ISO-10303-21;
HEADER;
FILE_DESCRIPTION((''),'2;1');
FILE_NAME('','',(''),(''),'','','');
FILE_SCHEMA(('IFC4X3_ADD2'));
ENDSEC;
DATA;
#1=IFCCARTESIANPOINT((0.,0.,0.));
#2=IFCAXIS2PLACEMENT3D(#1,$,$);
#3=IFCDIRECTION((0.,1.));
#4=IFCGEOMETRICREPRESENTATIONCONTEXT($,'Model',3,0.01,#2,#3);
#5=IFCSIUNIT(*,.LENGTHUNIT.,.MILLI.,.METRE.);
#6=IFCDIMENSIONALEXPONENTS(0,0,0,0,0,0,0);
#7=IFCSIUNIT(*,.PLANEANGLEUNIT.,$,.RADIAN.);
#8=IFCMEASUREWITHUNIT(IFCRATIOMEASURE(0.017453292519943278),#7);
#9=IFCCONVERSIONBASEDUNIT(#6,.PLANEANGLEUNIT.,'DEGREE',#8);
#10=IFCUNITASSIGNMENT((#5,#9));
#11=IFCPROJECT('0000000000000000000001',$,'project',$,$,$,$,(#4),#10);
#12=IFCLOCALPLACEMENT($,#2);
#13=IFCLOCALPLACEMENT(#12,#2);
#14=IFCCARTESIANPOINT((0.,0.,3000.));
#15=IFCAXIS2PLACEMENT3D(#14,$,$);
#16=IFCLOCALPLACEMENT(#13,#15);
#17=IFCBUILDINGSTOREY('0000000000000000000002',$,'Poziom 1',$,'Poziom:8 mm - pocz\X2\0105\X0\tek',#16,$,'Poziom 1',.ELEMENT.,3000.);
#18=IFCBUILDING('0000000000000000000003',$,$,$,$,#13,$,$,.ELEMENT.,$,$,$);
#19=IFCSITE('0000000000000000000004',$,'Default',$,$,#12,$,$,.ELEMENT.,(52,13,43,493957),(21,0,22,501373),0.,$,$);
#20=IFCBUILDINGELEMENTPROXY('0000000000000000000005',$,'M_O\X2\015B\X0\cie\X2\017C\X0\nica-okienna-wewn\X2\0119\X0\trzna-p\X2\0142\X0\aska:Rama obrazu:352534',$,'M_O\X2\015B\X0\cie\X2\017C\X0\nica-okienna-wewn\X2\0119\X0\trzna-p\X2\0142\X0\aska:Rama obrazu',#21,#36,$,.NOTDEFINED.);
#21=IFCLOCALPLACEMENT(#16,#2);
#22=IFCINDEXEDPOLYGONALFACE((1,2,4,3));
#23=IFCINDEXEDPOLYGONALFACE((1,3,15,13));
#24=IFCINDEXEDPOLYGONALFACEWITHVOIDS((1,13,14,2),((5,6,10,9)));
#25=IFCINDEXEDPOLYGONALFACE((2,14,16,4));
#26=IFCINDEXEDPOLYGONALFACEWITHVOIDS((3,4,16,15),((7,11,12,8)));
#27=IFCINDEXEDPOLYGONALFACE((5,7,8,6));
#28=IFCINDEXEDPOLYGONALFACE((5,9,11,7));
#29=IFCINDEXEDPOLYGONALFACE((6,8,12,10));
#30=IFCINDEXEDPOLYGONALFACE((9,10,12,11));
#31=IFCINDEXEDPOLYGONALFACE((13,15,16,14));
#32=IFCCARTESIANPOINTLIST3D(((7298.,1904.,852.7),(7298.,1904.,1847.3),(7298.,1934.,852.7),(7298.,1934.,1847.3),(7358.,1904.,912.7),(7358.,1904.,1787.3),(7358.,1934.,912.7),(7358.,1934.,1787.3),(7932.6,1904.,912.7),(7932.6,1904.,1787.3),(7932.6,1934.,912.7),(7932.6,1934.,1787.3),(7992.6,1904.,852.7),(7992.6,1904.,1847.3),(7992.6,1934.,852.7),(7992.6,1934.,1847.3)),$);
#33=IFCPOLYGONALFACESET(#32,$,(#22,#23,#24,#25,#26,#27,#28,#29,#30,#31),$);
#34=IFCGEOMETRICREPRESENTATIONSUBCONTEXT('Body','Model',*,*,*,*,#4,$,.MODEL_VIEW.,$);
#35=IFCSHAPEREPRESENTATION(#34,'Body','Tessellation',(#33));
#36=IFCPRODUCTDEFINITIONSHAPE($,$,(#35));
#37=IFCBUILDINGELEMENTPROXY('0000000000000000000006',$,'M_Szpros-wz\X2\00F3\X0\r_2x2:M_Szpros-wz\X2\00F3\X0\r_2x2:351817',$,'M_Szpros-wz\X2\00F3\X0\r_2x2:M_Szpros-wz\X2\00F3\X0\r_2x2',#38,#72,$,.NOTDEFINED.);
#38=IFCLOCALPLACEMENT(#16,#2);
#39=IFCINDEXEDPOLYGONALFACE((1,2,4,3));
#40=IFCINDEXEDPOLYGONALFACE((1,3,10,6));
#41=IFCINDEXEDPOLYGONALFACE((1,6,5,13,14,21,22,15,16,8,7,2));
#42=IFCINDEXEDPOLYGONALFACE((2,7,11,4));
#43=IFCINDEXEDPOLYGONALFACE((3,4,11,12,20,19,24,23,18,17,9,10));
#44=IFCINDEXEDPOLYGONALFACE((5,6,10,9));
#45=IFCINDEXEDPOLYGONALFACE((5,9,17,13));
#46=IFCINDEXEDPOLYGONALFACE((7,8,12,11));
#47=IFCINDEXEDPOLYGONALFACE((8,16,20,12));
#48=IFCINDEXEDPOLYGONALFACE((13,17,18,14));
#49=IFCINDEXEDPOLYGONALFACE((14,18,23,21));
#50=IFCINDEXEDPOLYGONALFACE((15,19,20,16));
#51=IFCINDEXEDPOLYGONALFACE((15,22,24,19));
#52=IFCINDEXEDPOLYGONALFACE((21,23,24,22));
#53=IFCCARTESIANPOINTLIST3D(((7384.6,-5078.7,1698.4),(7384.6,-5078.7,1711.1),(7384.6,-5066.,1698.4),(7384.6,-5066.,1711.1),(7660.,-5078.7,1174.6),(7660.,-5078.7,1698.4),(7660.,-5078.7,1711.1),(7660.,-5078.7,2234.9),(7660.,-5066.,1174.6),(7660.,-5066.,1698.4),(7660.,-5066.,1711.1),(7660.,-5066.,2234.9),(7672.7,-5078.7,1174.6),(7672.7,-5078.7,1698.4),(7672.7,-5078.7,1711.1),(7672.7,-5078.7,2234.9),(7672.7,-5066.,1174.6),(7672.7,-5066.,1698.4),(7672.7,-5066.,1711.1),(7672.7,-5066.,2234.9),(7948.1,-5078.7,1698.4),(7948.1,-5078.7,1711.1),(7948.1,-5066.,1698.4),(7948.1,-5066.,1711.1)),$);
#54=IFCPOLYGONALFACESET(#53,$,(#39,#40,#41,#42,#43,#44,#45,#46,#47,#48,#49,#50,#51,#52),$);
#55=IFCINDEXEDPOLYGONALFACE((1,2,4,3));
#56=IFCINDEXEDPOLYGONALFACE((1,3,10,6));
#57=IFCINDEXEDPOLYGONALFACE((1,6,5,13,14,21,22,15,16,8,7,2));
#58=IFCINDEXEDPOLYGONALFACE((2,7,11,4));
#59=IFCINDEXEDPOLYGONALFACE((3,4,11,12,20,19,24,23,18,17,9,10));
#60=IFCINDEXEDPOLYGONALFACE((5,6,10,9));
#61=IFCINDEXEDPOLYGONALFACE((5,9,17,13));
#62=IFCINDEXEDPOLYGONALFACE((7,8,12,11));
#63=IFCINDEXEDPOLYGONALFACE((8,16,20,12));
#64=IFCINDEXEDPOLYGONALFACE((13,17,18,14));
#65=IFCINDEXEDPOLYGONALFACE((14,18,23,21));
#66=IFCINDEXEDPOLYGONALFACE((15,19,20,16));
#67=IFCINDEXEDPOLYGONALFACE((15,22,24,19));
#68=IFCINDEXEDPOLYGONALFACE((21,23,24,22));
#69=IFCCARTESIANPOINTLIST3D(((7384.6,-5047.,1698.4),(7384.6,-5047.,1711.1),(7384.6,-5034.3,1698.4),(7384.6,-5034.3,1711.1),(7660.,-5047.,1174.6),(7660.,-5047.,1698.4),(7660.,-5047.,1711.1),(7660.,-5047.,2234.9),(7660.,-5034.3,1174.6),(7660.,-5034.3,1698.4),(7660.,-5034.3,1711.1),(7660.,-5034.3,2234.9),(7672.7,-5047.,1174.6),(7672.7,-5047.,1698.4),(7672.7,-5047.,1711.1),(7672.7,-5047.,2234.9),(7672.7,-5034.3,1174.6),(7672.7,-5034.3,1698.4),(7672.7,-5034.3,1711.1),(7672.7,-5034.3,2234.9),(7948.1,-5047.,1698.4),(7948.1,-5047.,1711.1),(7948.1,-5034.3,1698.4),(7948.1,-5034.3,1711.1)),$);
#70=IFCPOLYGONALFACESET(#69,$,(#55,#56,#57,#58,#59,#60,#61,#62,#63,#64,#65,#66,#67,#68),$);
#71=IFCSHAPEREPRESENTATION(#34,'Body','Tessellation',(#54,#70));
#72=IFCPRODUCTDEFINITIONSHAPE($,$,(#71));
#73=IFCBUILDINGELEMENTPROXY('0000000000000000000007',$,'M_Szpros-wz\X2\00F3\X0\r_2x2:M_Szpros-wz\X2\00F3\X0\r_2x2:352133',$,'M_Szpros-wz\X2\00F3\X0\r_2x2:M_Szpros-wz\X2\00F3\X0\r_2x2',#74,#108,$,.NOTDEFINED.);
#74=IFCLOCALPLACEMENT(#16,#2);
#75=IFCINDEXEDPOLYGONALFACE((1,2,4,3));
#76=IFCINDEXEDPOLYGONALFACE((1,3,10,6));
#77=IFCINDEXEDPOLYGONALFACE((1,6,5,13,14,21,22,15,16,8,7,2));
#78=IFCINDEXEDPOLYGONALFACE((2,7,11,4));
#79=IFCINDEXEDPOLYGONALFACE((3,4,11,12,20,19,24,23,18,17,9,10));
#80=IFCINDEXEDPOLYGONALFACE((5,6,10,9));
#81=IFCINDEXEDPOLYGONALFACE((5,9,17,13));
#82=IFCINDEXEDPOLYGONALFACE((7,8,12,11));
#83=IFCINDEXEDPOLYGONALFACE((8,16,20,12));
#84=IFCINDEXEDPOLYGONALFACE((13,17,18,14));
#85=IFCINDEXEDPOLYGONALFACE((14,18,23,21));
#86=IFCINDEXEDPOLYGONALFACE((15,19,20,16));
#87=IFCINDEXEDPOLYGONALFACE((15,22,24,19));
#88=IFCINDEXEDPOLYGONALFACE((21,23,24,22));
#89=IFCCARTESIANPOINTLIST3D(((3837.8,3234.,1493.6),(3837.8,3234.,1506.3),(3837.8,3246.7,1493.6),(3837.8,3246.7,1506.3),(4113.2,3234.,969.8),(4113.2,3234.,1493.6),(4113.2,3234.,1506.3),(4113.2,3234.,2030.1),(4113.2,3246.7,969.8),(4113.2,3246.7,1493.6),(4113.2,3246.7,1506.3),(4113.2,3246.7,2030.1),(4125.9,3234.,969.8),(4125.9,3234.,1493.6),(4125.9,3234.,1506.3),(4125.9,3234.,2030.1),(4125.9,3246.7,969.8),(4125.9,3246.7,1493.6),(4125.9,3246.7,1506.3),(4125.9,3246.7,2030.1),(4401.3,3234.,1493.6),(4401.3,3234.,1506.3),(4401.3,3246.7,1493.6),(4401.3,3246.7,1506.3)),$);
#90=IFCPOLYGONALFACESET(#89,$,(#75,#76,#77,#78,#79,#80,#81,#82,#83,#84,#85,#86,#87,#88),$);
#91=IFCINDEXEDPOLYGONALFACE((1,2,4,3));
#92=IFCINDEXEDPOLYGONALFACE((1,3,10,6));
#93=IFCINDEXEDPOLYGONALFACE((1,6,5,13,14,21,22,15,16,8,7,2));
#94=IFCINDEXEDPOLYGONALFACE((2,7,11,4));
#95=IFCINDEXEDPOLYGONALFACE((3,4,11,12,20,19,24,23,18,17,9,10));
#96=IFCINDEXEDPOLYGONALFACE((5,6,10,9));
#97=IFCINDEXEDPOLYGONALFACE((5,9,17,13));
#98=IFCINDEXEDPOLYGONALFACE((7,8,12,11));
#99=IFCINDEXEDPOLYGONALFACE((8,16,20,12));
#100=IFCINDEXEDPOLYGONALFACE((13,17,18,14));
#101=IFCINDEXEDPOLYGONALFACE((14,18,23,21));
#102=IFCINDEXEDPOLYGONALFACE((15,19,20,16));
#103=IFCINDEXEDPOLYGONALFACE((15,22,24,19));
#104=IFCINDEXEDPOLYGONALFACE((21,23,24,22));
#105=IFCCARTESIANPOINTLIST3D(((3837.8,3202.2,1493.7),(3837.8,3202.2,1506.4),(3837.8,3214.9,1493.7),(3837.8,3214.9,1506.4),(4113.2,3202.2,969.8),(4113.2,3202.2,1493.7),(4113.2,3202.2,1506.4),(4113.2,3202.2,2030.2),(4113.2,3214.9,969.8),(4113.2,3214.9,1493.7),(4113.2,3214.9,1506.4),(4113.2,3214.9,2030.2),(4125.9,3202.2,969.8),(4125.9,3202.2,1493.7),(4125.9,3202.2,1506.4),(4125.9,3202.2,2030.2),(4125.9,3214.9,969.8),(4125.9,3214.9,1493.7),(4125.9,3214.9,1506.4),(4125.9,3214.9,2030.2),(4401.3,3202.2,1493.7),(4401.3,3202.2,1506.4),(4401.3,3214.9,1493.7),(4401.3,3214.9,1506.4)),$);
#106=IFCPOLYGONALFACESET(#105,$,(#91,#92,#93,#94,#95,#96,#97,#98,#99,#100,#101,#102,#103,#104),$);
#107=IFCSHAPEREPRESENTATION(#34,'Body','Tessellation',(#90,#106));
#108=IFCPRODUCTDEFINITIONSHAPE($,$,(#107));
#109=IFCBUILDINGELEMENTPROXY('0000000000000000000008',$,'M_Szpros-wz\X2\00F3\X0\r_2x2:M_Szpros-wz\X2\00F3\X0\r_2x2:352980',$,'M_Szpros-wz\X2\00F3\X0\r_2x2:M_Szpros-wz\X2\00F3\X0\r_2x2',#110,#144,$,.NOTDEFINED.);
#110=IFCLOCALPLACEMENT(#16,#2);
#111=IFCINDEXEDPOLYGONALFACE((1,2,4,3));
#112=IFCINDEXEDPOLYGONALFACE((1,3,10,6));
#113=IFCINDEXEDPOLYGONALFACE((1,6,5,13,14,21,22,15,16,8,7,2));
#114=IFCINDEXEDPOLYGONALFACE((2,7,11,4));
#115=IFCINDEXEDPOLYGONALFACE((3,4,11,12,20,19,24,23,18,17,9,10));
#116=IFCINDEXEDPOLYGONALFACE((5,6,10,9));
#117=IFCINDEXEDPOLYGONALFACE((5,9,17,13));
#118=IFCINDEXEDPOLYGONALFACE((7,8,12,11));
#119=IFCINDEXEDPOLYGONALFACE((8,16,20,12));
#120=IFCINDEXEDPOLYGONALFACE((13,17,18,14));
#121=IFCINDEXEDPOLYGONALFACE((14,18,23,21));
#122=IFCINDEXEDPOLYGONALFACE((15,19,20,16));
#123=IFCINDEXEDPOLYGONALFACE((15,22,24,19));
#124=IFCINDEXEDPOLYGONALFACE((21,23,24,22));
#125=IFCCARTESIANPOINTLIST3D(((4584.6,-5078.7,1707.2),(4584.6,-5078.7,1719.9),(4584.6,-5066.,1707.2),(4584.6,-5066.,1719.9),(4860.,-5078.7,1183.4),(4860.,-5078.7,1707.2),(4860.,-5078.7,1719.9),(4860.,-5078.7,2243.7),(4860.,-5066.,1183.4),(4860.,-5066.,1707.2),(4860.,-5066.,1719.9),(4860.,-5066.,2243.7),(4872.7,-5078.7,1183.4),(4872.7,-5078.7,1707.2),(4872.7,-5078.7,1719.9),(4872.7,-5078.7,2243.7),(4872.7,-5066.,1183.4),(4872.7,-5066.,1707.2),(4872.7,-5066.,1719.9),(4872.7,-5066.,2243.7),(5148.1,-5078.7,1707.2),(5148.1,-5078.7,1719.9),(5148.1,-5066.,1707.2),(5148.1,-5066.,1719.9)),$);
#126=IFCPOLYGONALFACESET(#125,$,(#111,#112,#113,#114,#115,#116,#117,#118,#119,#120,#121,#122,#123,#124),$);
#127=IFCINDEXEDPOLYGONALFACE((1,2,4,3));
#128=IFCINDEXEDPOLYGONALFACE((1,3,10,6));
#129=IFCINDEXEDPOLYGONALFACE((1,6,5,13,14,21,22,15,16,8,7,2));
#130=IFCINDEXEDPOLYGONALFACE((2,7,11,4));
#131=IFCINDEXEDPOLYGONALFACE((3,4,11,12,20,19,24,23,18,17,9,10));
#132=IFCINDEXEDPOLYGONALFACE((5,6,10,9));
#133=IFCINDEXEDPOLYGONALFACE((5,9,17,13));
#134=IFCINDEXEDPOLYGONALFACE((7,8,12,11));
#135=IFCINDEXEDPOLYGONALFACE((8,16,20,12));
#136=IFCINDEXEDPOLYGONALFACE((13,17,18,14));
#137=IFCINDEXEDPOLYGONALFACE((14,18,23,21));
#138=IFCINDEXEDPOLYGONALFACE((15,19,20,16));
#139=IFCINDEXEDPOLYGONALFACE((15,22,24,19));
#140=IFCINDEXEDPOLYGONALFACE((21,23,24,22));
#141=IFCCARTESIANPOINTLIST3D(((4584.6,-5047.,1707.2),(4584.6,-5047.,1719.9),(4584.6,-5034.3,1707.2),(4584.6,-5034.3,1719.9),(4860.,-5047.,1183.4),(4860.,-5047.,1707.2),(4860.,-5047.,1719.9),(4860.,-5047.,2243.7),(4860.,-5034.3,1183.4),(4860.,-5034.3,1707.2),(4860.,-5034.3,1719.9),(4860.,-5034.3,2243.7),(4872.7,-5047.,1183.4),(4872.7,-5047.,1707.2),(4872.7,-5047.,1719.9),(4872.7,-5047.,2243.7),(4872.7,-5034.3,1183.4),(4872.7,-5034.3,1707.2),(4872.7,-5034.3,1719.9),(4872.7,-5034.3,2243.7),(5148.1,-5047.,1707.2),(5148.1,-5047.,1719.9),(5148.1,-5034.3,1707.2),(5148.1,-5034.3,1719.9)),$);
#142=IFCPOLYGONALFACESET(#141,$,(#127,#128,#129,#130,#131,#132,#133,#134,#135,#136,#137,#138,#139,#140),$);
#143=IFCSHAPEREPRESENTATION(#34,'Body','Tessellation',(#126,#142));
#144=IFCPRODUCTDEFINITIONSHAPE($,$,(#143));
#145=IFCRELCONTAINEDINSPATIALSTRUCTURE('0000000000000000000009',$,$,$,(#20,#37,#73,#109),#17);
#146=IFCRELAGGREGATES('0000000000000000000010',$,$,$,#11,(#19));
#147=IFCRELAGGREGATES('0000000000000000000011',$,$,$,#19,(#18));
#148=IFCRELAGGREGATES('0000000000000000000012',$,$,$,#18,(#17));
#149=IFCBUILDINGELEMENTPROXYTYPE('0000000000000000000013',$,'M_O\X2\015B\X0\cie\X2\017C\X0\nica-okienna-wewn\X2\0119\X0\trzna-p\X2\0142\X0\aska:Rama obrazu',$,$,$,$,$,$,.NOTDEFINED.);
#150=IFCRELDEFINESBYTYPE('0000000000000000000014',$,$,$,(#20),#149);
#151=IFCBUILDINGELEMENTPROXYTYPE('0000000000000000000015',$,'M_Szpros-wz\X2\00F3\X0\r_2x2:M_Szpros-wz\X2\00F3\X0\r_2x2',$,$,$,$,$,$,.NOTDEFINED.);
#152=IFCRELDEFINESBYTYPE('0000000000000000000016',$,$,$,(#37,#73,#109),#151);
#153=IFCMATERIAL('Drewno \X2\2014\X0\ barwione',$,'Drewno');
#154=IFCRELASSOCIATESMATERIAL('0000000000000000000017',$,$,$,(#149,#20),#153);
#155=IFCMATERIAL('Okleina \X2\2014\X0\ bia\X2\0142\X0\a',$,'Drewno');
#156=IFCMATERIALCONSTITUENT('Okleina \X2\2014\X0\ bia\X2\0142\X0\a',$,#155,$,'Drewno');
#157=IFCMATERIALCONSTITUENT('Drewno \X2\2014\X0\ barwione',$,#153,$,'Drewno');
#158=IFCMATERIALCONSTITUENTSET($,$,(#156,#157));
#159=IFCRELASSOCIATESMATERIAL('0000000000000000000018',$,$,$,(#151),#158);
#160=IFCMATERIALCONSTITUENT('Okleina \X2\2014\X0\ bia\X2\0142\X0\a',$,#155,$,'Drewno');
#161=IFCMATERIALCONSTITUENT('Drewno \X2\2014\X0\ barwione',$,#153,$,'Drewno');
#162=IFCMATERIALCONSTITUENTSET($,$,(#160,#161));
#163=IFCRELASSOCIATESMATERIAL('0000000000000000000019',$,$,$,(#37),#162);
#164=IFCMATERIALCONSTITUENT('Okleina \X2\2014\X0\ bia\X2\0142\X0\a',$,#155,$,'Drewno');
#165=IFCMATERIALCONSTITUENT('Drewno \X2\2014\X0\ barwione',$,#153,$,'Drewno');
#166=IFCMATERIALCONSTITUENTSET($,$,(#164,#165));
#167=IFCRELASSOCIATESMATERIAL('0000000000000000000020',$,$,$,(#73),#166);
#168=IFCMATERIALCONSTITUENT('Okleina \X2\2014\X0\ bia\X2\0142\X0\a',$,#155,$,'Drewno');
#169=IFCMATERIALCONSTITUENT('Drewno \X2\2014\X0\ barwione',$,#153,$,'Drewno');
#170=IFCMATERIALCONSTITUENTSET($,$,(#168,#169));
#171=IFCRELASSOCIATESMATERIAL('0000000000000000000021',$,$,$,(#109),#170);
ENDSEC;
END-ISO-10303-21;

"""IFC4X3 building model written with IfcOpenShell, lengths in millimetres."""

from ifc_helpers import new_model, entity, si_unit, converted_unit, direction, frame, origin, place, context, subcontext, project, spatial, polyline, outline, extrude, source, transform, mapped, material, constituent, constituent_set, type_object, type_shapes, element, save


model = new_model("IFC4X3")

# Units and contexts
model_context = context("Model", 3, precision=0.01, world=origin(), true_north=direction((0.0, 1.0)))
body_context = subcontext(model_context, "Body", "Model", "MODEL_VIEW")
ifc_project = project(units=[si_unit("LENGTHUNIT", "METRE", prefix="MILLI"), converted_unit("PLANEANGLEUNIT", "DEGREE", entity("IfcRatioMeasure", 0.017453292519943278), si_unit("PLANEANGLEUNIT", "RADIAN"), dimensions=[0, 0, 0, 0, 0, 0, 0])], contexts=[model_context])

# Site, building, storey
site_placement = place(None, origin())
site = spatial("IfcSite", under=ifc_project, at=site_placement, Name="Default", CompositionType="ELEMENT", RefLatitude=(52, 13, 43, 493957), RefLongitude=(21, 0, 22, 501373), RefElevation=0.0)
building_placement = place(site_placement, origin())
building = spatial("IfcBuilding", under=site, at=building_placement, CompositionType="ELEMENT")
storey_placement = place(building_placement, frame((0.0, 0.0, 3000.0)))
storey = spatial("IfcBuildingStorey", under=building, at=storey_placement, Name="Poziom 1", ObjectType="Poziom:8 mm - początek", LongName="Poziom 1", CompositionType="ELEMENT", Elevation=3000.0)

# Building element proxies
ifc_material_1 = material(Name="Okleina — biała", Category="Drewno")
ifc_material_2 = material(Name="Drewno — barwione", Category="Drewno")
building_element_proxy_type_1 = type_object("IfcBuildingElementProxyType", Name="M_Ościeżnica-okienna-wewnętrzna-płaska:Rama obrazu", PredefinedType="NOTDEFINED", material=ifc_material_2)
shared_shape_1 = source(origin(), body_context, "Body", "SweptSolid", [
    extrude(outline(polyline([(-347.3, -497.3), (347.3, -497.3), (347.3, 497.3), (-347.3, 497.3), (-347.3, -497.3)]), holes=[polyline([(-287.3, -437.3), (-287.3, 437.3), (287.3, 437.3), (287.3, -437.3), (-287.3, -437.3)])]), frame((0.0, -450.0, 0.0), z_axis=(0.0, 0.0, 1.0), x_axis=(-1.0, 0.0, 0.0)), (0.0, 0.0, 1.0), 30.0),
])
type_shapes(building_element_proxy_type_1, [shared_shape_1])
proxy_1_placement = place(storey_placement, frame((7645.3, 1934.0, 1800.0), z_axis=(0.0, -1.0, 0.0), x_axis=(1.0, 0.0, 0.0)))
element("IfcBuildingElementProxy", 1, at=proxy_1_placement, inside=storey, type_object=building_element_proxy_type_1, material=ifc_material_2, Name="M_Ościeżnica-okienna-wewnętrzna-płaska:Rama obrazu:352534", ObjectType="M_Ościeżnica-okienna-wewnętrzna-płaska:Rama obrazu", PredefinedType="NOTDEFINED", context=body_context, shape_type="MappedRepresentation", body=[
    mapped(shared_shape_1, transform((0.0, 0.0, 0.0), scale=1.0)),
])
ifc_constituent_1 = constituent(ifc_material_1, Name="Okleina — biała", Category="Drewno")
ifc_constituent_2 = constituent(ifc_material_2, Name="Drewno — barwione", Category="Drewno")
ifc_constituent_set_1 = constituent_set(constituents=[ifc_constituent_1, ifc_constituent_2])
ifc_constituent_3 = constituent(ifc_material_1, Name="Okleina — biała", Category="Drewno")
ifc_constituent_4 = constituent(ifc_material_2, Name="Drewno — barwione", Category="Drewno")
ifc_constituent_set_2 = constituent_set(constituents=[ifc_constituent_3, ifc_constituent_4])
building_element_proxy_type_2 = type_object("IfcBuildingElementProxyType", Name="M_Szpros-wzór_2x2:M_Szpros-wzór_2x2", PredefinedType="NOTDEFINED", material=ifc_constituent_set_2)
shared_shape_2 = source(origin(), body_context, "Body", "SweptSolid", [
    extrude(outline(polyline([(6.4, -6.4), (530.1, -6.4), (530.1, 6.3), (6.4, 6.3), (6.4, 281.7), (-6.3, 281.7), (-6.3, 6.3), (-530.2, 6.3), (-530.2, -6.4), (-6.3, -6.4), (-6.3, -281.7), (6.4, -281.7), (6.4, -6.4)])), frame((0.0, 9.5, 530.1), z_axis=(0.0, 1.0, 0.0), x_axis=(0.0, 0.0, 1.0)), (0.0, 0.0, 1.0), 12.7),
    extrude(outline(polyline([(6.4, -6.4), (530.2, -6.4), (530.2, 6.3), (6.4, 6.3), (6.4, 281.7), (-6.3, 281.7), (-6.3, 6.3), (-530.2, 6.3), (-530.2, -6.4), (-6.3, -6.4), (-6.3, -281.7), (6.4, -281.7), (6.4, -6.4)])), frame((0.0, -22.2, 530.2), z_axis=(0.0, 1.0, 0.0), x_axis=(0.0, 0.0, 1.0)), (0.0, 0.0, 1.0), 12.7),
])
type_shapes(building_element_proxy_type_2, [shared_shape_2])
proxy_2_placement = place(storey_placement, frame((7666.4, -5056.5, 1174.6), z_axis=(0.0, 0.0, 1.0), x_axis=(-1.0, 0.0, 0.0)))
element("IfcBuildingElementProxy", 2, at=proxy_2_placement, inside=storey, type_object=building_element_proxy_type_2, material=ifc_constituent_set_1, Name="M_Szpros-wzór_2x2:M_Szpros-wzór_2x2:351817", ObjectType="M_Szpros-wzór_2x2:M_Szpros-wzór_2x2", PredefinedType="NOTDEFINED", context=body_context, shape_type="MappedRepresentation", body=[
    mapped(shared_shape_2, transform((0.0, 0.0, 0.0), scale=1.0)),
])
ifc_constituent_5 = constituent(ifc_material_1, Name="Okleina — biała", Category="Drewno")
ifc_constituent_6 = constituent(ifc_material_2, Name="Drewno — barwione", Category="Drewno")
ifc_constituent_set_3 = constituent_set(constituents=[ifc_constituent_5, ifc_constituent_6])
proxy_3_placement = place(storey_placement, frame((4119.6, 3224.5, 969.8)))
element("IfcBuildingElementProxy", 3, at=proxy_3_placement, inside=storey, type_object=building_element_proxy_type_2, material=ifc_constituent_set_3, Name="M_Szpros-wzór_2x2:M_Szpros-wzór_2x2:352133", ObjectType="M_Szpros-wzór_2x2:M_Szpros-wzór_2x2", PredefinedType="NOTDEFINED", context=body_context, shape_type="MappedRepresentation", body=[
    mapped(shared_shape_2, transform((0.0, 0.0, 0.0), scale=1.0)),
])
ifc_constituent_7 = constituent(ifc_material_1, Name="Okleina — biała", Category="Drewno")
ifc_constituent_8 = constituent(ifc_material_2, Name="Drewno — barwione", Category="Drewno")
ifc_constituent_set_4 = constituent_set(constituents=[ifc_constituent_7, ifc_constituent_8])
proxy_4_placement = place(storey_placement, frame((4866.4, -5056.5, 1183.4), z_axis=(0.0, 0.0, 1.0), x_axis=(-1.0, 0.0, 0.0)))
element("IfcBuildingElementProxy", 4, at=proxy_4_placement, inside=storey, type_object=building_element_proxy_type_2, material=ifc_constituent_set_4, Name="M_Szpros-wzór_2x2:M_Szpros-wzór_2x2:352980", ObjectType="M_Szpros-wzór_2x2:M_Szpros-wzór_2x2", PredefinedType="NOTDEFINED", context=body_context, shape_type="MappedRepresentation", body=[
    mapped(shared_shape_2, transform((0.0, 0.0, 0.0), scale=1.0)),
])

save(model, "model.ifc")
